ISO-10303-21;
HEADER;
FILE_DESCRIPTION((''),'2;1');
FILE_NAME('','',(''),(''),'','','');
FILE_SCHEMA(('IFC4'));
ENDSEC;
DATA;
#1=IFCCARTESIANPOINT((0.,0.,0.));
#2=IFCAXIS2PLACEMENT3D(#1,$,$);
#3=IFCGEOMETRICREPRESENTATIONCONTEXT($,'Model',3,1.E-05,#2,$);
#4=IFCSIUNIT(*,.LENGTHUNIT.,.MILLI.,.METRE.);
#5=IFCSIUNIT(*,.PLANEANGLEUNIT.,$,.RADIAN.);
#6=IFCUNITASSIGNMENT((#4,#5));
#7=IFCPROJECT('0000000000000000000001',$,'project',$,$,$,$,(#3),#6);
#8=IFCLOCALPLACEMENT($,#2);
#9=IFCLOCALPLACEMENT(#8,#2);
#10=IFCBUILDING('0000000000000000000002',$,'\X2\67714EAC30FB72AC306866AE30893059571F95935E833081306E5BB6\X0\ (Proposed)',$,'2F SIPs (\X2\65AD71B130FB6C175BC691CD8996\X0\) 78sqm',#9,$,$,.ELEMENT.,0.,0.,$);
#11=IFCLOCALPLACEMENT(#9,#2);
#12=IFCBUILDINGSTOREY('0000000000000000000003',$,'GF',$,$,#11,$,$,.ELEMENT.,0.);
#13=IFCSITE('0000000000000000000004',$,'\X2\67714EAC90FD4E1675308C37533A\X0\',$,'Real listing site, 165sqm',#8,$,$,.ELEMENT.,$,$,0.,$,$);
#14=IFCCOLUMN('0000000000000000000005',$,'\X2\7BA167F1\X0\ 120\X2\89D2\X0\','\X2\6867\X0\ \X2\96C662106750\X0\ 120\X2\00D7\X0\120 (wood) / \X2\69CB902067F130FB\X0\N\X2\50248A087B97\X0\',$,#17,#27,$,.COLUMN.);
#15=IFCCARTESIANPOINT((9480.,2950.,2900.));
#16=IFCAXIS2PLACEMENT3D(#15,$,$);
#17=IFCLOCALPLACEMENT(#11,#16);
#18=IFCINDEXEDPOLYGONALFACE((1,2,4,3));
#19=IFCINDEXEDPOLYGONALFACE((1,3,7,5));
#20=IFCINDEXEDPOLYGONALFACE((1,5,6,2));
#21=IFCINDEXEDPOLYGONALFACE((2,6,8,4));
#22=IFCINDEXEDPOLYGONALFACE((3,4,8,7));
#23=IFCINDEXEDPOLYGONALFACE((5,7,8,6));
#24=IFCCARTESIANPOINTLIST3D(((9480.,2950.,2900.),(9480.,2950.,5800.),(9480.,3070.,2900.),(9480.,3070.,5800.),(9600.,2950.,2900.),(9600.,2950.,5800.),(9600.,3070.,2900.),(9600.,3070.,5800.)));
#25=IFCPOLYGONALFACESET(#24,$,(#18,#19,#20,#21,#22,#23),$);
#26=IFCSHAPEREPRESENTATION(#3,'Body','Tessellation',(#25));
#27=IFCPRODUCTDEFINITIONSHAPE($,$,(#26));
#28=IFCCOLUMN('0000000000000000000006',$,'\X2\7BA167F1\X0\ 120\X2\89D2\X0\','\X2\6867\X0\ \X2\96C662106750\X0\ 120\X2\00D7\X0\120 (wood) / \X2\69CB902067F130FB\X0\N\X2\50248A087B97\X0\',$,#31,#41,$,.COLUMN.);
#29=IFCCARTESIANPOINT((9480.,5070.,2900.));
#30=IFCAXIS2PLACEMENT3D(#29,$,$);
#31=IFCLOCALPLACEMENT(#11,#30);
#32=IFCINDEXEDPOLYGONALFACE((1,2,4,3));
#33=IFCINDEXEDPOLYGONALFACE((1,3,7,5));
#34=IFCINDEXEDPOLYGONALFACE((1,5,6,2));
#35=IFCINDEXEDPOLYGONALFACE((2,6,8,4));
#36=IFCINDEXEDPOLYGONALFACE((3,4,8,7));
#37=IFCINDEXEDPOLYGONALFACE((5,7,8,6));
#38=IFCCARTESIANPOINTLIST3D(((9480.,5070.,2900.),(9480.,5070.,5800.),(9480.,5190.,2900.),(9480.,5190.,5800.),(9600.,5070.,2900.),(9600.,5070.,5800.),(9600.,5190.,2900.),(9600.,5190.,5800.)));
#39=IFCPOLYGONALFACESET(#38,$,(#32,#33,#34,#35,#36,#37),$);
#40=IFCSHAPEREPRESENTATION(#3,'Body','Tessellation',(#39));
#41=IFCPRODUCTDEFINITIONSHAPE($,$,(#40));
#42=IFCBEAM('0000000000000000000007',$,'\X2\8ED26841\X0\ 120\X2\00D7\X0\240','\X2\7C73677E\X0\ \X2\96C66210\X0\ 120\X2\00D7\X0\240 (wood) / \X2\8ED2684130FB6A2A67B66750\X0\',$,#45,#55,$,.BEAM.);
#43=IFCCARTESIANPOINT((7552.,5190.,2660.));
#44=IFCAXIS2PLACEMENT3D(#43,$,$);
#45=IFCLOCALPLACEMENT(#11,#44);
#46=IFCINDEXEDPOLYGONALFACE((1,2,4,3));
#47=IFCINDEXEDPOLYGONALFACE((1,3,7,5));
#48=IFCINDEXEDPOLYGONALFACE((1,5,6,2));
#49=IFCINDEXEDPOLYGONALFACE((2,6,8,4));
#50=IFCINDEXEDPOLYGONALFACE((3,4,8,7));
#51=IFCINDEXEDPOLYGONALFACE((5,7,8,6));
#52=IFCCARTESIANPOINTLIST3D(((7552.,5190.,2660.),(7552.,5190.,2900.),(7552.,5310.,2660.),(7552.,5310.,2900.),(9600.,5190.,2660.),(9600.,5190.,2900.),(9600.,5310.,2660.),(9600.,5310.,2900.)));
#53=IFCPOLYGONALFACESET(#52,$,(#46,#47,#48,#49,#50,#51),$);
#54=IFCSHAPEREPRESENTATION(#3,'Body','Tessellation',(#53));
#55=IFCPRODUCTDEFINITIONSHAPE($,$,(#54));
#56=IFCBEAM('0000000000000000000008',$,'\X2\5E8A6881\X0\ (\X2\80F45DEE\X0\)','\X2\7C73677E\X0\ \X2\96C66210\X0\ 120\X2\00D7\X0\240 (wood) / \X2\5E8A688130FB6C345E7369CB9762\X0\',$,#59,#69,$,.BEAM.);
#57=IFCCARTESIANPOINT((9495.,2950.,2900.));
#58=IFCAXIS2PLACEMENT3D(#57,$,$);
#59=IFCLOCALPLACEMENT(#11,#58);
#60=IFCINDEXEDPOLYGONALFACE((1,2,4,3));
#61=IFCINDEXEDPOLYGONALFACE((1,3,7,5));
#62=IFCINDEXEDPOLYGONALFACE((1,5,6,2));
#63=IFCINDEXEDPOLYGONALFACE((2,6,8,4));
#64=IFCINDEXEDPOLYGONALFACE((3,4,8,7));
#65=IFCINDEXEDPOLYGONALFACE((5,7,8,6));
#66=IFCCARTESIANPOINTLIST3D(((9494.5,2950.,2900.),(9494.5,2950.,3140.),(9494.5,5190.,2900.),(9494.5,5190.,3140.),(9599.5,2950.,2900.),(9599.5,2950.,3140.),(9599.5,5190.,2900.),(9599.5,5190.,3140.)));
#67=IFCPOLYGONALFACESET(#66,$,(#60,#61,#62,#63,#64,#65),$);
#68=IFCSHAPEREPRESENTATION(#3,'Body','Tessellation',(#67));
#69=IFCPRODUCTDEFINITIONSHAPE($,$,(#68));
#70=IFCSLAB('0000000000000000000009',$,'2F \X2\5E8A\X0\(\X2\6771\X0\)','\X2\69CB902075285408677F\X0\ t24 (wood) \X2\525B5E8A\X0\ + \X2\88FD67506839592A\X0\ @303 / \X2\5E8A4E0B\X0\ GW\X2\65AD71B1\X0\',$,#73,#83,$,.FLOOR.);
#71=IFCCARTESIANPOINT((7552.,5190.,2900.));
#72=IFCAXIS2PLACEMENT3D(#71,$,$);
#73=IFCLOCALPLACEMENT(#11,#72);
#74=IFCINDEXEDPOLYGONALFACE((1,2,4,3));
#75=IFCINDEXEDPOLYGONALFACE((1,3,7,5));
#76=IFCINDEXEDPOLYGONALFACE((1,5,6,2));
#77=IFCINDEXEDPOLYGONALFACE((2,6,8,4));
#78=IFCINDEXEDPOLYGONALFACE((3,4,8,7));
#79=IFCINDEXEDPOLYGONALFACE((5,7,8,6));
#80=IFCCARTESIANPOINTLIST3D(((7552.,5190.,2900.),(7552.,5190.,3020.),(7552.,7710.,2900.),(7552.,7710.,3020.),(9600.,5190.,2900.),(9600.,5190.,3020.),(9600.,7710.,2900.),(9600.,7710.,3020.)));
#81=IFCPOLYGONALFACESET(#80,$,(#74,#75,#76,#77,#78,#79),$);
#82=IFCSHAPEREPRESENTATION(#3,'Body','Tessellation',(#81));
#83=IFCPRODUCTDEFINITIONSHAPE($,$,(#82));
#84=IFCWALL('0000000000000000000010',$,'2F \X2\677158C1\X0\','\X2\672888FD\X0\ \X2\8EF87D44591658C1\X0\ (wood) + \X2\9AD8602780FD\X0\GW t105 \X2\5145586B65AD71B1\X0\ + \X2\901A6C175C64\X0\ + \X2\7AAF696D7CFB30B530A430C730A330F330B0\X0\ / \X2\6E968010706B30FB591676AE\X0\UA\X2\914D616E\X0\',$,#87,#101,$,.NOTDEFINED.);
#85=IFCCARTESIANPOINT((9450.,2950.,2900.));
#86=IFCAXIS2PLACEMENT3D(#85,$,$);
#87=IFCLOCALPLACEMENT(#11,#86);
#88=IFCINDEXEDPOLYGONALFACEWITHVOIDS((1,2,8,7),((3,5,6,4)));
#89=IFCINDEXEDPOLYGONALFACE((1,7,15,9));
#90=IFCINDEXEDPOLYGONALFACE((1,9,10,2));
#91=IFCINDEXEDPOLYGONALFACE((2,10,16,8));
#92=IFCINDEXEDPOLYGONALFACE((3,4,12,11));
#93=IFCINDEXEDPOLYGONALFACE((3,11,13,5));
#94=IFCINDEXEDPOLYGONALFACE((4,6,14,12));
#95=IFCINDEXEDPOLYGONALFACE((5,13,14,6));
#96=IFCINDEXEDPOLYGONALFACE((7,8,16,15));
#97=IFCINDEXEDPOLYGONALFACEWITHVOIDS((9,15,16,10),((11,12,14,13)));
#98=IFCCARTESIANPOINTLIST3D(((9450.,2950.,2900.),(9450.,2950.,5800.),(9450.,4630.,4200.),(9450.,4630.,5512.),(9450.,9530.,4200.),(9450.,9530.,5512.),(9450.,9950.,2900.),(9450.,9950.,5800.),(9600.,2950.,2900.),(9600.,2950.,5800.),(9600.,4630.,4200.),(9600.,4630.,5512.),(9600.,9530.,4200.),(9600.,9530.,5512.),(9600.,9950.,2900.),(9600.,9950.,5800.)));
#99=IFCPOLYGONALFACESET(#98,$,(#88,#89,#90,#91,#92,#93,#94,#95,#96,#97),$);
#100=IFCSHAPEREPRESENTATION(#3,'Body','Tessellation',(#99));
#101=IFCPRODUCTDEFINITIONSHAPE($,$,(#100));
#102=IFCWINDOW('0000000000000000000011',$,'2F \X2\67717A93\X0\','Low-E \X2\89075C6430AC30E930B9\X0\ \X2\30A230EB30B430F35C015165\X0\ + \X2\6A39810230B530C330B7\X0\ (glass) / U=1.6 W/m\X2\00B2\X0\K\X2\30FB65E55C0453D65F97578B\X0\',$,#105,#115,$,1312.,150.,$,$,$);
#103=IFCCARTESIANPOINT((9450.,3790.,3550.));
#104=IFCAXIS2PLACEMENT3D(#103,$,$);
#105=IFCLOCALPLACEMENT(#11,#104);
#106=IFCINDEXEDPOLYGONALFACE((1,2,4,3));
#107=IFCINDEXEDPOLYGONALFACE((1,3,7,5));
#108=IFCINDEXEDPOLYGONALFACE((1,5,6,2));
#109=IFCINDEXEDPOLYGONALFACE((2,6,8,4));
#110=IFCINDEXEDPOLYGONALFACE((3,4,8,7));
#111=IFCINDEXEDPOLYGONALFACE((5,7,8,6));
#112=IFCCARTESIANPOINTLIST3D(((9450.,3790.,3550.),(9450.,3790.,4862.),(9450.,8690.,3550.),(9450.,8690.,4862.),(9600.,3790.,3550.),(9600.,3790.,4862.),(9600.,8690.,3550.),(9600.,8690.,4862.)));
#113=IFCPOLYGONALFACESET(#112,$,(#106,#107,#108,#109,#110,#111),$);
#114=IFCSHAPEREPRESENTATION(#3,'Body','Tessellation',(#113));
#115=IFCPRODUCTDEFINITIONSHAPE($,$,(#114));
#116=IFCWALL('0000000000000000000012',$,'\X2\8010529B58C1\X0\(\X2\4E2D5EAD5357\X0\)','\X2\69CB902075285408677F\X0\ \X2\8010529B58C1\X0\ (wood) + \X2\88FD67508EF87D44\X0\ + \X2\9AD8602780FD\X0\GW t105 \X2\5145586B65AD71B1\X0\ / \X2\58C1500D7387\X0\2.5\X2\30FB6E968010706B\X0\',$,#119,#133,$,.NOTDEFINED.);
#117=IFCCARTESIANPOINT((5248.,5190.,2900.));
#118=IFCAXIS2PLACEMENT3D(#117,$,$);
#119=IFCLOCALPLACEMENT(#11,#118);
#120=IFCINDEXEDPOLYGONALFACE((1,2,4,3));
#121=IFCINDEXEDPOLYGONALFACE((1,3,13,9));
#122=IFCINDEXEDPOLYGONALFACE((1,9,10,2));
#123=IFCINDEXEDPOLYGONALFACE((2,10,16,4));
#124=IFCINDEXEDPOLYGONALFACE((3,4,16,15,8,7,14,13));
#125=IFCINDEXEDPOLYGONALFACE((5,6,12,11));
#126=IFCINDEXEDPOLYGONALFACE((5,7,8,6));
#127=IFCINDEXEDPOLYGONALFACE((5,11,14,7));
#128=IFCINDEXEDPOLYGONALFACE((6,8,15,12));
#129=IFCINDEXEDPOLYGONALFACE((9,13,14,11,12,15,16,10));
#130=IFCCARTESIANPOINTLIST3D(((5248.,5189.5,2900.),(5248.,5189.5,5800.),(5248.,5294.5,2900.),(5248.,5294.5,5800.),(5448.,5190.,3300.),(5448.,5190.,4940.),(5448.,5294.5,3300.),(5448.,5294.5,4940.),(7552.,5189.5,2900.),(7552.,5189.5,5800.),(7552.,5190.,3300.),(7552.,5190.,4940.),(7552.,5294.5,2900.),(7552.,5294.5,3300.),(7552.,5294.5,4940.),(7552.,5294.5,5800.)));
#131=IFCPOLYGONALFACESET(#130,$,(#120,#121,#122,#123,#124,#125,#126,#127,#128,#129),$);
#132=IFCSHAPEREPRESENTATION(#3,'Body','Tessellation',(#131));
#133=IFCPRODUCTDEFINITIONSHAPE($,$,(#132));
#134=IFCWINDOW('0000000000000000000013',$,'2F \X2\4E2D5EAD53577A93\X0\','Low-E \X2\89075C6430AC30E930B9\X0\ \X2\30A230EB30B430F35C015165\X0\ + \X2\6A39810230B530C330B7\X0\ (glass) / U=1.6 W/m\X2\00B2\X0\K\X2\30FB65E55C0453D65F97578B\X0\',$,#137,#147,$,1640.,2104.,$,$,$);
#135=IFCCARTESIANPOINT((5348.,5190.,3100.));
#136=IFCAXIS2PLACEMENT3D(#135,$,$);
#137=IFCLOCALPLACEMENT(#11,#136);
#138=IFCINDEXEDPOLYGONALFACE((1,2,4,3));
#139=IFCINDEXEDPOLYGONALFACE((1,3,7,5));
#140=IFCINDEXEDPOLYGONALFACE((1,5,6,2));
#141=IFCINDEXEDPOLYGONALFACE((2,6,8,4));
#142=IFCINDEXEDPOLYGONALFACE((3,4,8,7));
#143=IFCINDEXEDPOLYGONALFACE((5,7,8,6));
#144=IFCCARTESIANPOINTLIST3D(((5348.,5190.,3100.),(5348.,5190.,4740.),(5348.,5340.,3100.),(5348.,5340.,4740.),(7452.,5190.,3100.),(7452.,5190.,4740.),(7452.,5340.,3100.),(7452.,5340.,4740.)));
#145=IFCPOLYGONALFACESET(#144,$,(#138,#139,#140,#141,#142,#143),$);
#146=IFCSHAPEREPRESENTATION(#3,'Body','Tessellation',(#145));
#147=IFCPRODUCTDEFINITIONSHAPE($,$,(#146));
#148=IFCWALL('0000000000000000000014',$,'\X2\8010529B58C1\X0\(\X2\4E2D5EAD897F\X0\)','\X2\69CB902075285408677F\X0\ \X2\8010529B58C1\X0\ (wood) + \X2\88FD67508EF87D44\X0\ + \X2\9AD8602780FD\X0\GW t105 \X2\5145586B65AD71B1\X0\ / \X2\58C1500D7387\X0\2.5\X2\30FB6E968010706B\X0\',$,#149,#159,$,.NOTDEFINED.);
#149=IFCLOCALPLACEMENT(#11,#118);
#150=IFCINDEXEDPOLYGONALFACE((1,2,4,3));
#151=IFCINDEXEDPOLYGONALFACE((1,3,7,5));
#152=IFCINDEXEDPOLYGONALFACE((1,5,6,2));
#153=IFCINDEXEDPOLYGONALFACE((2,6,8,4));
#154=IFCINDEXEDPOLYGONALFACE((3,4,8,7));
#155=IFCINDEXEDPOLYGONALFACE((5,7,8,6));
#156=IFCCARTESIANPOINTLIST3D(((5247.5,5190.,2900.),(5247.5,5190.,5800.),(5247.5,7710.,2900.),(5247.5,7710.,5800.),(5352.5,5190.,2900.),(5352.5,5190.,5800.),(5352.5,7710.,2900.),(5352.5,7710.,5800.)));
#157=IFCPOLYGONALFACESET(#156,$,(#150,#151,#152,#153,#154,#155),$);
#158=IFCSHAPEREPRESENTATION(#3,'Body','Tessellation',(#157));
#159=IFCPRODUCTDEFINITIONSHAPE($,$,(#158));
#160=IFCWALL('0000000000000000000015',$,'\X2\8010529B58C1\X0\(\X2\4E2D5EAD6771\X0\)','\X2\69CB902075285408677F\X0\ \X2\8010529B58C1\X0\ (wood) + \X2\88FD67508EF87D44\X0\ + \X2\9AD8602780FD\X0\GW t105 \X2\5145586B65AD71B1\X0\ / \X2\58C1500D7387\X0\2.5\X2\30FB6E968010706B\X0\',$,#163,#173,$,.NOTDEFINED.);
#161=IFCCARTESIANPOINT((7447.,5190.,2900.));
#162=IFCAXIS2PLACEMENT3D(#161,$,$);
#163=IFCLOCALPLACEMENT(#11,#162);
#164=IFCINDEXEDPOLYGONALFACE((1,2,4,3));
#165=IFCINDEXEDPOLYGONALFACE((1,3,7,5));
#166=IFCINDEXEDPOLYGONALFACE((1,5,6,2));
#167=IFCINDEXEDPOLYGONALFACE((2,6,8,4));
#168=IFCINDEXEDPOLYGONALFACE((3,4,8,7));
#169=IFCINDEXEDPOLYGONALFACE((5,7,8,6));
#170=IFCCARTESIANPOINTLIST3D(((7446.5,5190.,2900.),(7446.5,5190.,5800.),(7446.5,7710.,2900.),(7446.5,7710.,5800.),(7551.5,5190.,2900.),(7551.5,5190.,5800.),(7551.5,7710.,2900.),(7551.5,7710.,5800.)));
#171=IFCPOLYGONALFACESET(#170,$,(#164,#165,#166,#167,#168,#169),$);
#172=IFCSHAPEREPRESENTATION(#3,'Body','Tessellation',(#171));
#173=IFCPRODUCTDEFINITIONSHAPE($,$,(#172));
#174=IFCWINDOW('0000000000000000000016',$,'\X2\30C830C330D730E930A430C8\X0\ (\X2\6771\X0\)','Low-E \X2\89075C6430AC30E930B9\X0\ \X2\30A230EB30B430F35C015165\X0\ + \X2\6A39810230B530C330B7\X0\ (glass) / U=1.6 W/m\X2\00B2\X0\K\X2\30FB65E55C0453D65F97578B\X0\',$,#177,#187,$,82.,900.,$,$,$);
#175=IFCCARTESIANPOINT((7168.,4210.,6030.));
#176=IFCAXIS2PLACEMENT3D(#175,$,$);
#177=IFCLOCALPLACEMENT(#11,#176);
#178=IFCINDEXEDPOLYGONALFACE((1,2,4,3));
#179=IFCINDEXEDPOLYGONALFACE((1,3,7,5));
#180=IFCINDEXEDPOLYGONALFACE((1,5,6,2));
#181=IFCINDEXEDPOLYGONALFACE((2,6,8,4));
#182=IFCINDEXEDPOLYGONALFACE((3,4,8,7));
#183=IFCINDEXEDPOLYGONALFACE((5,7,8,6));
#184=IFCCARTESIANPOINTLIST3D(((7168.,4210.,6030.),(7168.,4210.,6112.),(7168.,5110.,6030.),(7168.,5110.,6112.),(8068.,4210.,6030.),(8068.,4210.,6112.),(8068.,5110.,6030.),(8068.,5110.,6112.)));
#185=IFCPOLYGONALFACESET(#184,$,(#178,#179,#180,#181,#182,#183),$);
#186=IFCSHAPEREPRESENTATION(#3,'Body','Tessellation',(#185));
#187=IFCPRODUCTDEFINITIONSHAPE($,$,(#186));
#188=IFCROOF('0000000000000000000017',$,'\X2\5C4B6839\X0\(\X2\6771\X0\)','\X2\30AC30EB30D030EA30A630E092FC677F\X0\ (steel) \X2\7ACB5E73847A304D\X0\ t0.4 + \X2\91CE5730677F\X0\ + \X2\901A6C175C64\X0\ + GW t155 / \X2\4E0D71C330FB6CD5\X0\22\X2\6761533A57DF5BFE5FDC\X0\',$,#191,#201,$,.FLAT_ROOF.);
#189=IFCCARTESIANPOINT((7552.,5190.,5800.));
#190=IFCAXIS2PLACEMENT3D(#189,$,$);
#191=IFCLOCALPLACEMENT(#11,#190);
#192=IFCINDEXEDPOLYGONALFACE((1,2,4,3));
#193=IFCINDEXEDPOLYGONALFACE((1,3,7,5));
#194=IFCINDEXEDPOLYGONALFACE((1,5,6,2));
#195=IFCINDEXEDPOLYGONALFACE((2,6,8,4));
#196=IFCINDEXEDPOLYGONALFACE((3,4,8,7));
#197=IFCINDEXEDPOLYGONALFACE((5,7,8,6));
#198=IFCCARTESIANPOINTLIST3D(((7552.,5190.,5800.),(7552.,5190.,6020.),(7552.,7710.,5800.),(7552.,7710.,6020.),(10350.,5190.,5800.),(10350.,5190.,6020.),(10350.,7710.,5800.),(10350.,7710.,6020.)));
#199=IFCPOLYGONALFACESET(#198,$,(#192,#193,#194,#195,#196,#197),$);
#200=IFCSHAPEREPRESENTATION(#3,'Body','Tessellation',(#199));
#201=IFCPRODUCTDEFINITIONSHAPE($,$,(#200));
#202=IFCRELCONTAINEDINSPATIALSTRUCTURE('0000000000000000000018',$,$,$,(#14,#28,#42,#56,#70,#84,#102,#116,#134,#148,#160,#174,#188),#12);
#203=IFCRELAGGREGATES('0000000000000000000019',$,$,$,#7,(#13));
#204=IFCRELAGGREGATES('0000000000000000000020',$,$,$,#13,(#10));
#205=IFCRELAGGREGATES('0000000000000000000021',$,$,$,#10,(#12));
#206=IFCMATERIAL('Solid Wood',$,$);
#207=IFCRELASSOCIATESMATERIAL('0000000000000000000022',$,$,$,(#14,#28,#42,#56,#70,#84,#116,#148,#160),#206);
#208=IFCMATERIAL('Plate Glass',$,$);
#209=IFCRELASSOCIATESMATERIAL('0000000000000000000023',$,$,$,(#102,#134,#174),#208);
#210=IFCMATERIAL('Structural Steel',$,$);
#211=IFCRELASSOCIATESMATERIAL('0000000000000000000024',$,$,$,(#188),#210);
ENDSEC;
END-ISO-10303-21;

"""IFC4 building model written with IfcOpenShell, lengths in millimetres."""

from ifc_helpers import new_model, si_unit, frame, frame_2d, origin, place, context, project, spatial, rectangle, extrude, material, element, fill, save


model = new_model("IFC4")

# Units and contexts
model_context = context("Model", 3, precision=1e-05, world=origin())
ifc_project = project(units=[si_unit("LENGTHUNIT", "METRE", prefix="MILLI"), si_unit("PLANEANGLEUNIT", "RADIAN")], contexts=[model_context])

# Site, building, storey
site_placement = place(None, origin())
site = spatial("IfcSite", under=ifc_project, at=site_placement, Name="東京都世田谷区", ObjectType="Real listing site, 165sqm", CompositionType="ELEMENT", RefElevation=0.0)
building_placement = place(site_placement, origin())
building = spatial("IfcBuilding", under=site, at=building_placement, Name="東京・犬と暮らす土間広めの家 (Proposed)", ObjectType="2F SIPs (断熱・気密重視) 78sqm", CompositionType="ELEMENT", ElevationOfRefHeight=0.0, ElevationOfTerrain=0.0)
storey_placement = place(building_placement, origin())
storey = spatial("IfcBuildingStorey", under=building, at=storey_placement, Name="GF", CompositionType="ELEMENT", Elevation=0.0)

# Columns
ifc_material_1 = material(Name="Solid Wood")
column_1_placement = place(storey_placement, frame((9480.0, 2950.0, 2900.0)))
element("IfcColumn", 1, at=column_1_placement, inside=storey, material=ifc_material_1, Name="管柱 120角", Description="桧 集成材 120×120 (wood) / 構造柱・N値計算", PredefinedType="COLUMN", context=model_context, shape_type="SweptSolid", body=[
    extrude(rectangle(XDim=120.0, YDim=120.0, at=frame_2d((60.0, 60.0))), frame((9480.0, 2950.0, 2900.0)), (0.0, 0.0, 1.0), 2900.0),
])
column_2_placement = place(storey_placement, frame((9480.0, 5070.0, 2900.0)))
element("IfcColumn", 2, at=column_2_placement, inside=storey, material=ifc_material_1, Name="管柱 120角", Description="桧 集成材 120×120 (wood) / 構造柱・N値計算", PredefinedType="COLUMN", context=model_context, shape_type="SweptSolid", body=[
    extrude(rectangle(XDim=120.0, YDim=120.0, at=frame_2d((60.0, 60.0))), frame((9480.0, 5070.0, 2900.0)), (0.0, 0.0, 1.0), 2900.0),
])

# Beams
beam_1_placement = place(storey_placement, frame((7552.0, 5190.0, 2660.0)))
element("IfcBeam", 3, at=beam_1_placement, inside=storey, material=ifc_material_1, Name="軒桁 120×240", Description="米松 集成 120×240 (wood) / 軒桁・横架材", PredefinedType="BEAM", context=model_context, shape_type="SweptSolid", body=[
    extrude(rectangle(XDim=2048.0, YDim=120.0, at=frame_2d((1024.0, 60.0))), frame((7552.0, 5190.0, 2660.0)), (0.0, 0.0, 1.0), 240.0),
])
beam_2_placement = place(storey_placement, frame((9495.0, 2950.0, 2900.0)))
element("IfcBeam", 4, at=beam_2_placement, inside=storey, material=ifc_material_1, Name="床梁 (胴差)", Description="米松 集成 120×240 (wood) / 床梁・水平構面", PredefinedType="BEAM", context=model_context, shape_type="SweptSolid", body=[
    extrude(rectangle(XDim=105.0, YDim=2240.0, at=frame_2d((52.0, 1120.0))), frame((9495.0, 2950.0, 2900.0)), (0.0, 0.0, 1.0), 240.0),
])

# Slab
slab_placement = place(storey_placement, frame((7552.0, 5190.0, 2900.0)))
element("IfcSlab", 5, at=slab_placement, inside=storey, material=ifc_material_1, Name="2F 床(東)", Description="構造用合板 t24 (wood) 剛床 + 製材根太 @303 / 床下 GW断熱", PredefinedType="FLOOR", context=model_context, shape_type="SweptSolid", body=[
    extrude(rectangle(XDim=2048.0, YDim=2520.0, at=frame_2d((1024.0, 1260.0))), frame((7552.0, 5190.0, 2900.0)), (0.0, 0.0, 1.0), 120.0),
])

# Walls, openings, windows
wall_1_placement = place(storey_placement, frame((9450.0, 2950.0, 2900.0)))
wall_1 = element("IfcWall", 6, at=wall_1_placement, inside=storey, material=ifc_material_1, Name="2F 東壁", Description="木製 軸組外壁 (wood) + 高性能GW t105 充填断熱 + 通気層 + 窯業系サイディング / 準耐火・外皮UA配慮", PredefinedType="NOTDEFINED", context=model_context, shape_type="SweptSolid", body=[
    extrude(rectangle(XDim=150.0, YDim=7000.0, at=frame_2d((75.0, 3500.0))), frame((9450.0, 2950.0, 2900.0)), (0.0, 0.0, 1.0), 2900.0),
])
opening_1_placement = place(storey_placement, frame((9450.0, 3790.0, 3550.0)))
opening_1 = element("IfcOpeningElement", 7, at=opening_1_placement, cuts=wall_1, PredefinedType="NOTDEFINED", context=model_context, shape_type="SweptSolid", body=[
    extrude(rectangle(XDim=150.0, YDim=4900.0, at=frame_2d((75.0, 2450.0))), frame((9450.0, 3790.0, 3550.0)), (0.0, 0.0, 1.0), 1312.0),
])
ifc_material_2 = material(Name="Plate Glass")
window_1_placement = place(storey_placement, frame((9450.0, 3790.0, 3550.0)))
window_1 = element("IfcWindow", 8, at=window_1_placement, inside=storey, material=ifc_material_2, Name="2F 東窓", Description="Low-E 複層ガラス アルゴン封入 + 樹脂サッシ (glass) / U=1.6 W/m²K・日射取得型", OverallHeight=1312.0, OverallWidth=150.0, context=model_context, shape_type="SweptSolid", body=[
    extrude(rectangle(XDim=150.0, YDim=4900.0, at=frame_2d((75.0, 2450.0))), frame((9450.0, 3790.0, 3550.0)), (0.0, 0.0, 1.0), 1312.0),
])
fill(opening_1, window_1)
wall_2_placement = place(storey_placement, frame((5248.0, 5190.0, 2900.0)))
wall_2 = element("IfcWall", 9, at=wall_2_placement, inside=storey, material=ifc_material_1, Name="耐力壁(中庭南)", Description="構造用合板 耐力壁 (wood) + 製材軸組 + 高性能GW t105 充填断熱 / 壁倍率2.5・準耐火", PredefinedType="NOTDEFINED", context=model_context, shape_type="SweptSolid", body=[
    extrude(rectangle(XDim=2304.0, YDim=105.0, at=frame_2d((1152.0, 52.0))), frame((5248.0, 5190.0, 2900.0)), (0.0, 0.0, 1.0), 2900.0),
])
opening_2_placement = place(storey_placement, frame((5348.0, 5190.0, 3100.0)))
opening_2 = element("IfcOpeningElement", 10, at=opening_2_placement, cuts=wall_2, PredefinedType="NOTDEFINED", context=model_context, shape_type="SweptSolid", body=[
    extrude(rectangle(XDim=2104.0, YDim=150.0, at=frame_2d((1052.0, 75.0))), frame((5348.0, 5190.0, 3100.0)), (0.0, 0.0, 1.0), 1640.0),
])
window_2_placement = place(storey_placement, frame((5348.0, 5190.0, 3100.0)))
window_2 = element("IfcWindow", 11, at=window_2_placement, inside=storey, material=ifc_material_2, Name="2F 中庭南窓", Description="Low-E 複層ガラス アルゴン封入 + 樹脂サッシ (glass) / U=1.6 W/m²K・日射取得型", OverallHeight=1640.0, OverallWidth=2104.0, context=model_context, shape_type="SweptSolid", body=[
    extrude(rectangle(XDim=2104.0, YDim=150.0, at=frame_2d((1052.0, 75.0))), frame((5348.0, 5190.0, 3100.0)), (0.0, 0.0, 1.0), 1640.0),
])
fill(opening_2, window_2)

# Walls
wall_3_placement = place(storey_placement, frame((5248.0, 5190.0, 2900.0)))
element("IfcWall", 12, at=wall_3_placement, inside=storey, material=ifc_material_1, Name="耐力壁(中庭西)", Description="構造用合板 耐力壁 (wood) + 製材軸組 + 高性能GW t105 充填断熱 / 壁倍率2.5・準耐火", PredefinedType="NOTDEFINED", context=model_context, shape_type="SweptSolid", body=[
    extrude(rectangle(XDim=105.0, YDim=2520.0, at=frame_2d((52.0, 1260.0))), frame((5248.0, 5190.0, 2900.0)), (0.0, 0.0, 1.0), 2900.0),
])
wall_4_placement = place(storey_placement, frame((7447.0, 5190.0, 2900.0)))
element("IfcWall", 13, at=wall_4_placement, inside=storey, material=ifc_material_1, Name="耐力壁(中庭東)", Description="構造用合板 耐力壁 (wood) + 製材軸組 + 高性能GW t105 充填断熱 / 壁倍率2.5・準耐火", PredefinedType="NOTDEFINED", context=model_context, shape_type="SweptSolid", body=[
    extrude(rectangle(XDim=105.0, YDim=2520.0, at=frame_2d((52.0, 1260.0))), frame((7447.0, 5190.0, 2900.0)), (0.0, 0.0, 1.0), 2900.0),
])

# Window
window_3_placement = place(storey_placement, frame((7168.0, 4210.0, 6030.0)))
element("IfcWindow", 14, at=window_3_placement, inside=storey, material=ifc_material_2, Name="トップライト (東)", Description="Low-E 複層ガラス アルゴン封入 + 樹脂サッシ (glass) / U=1.6 W/m²K・日射取得型", OverallHeight=82.0, OverallWidth=900.0, context=model_context, shape_type="SweptSolid", body=[
    extrude(rectangle(XDim=900.0, YDim=900.0, at=frame_2d((450.0, 450.0))), frame((7168.0, 4210.0, 6030.0)), (0.0, 0.0, 1.0), 82.0),
])

# Roof
ifc_material_3 = material(Name="Structural Steel")
for number, where, name in (
    (15, (7552.0, 5190.0, 5800.0), "屋根(東)"),
):
    element("IfcRoof", number, at=place(storey_placement, frame(where)), inside=storey, material=ifc_material_3, Name=name, Description="ガルバリウム鋼板 (steel) 立平葺き t0.4 + 野地板 + 通気層 + GW t155 / 不燃・法22条区域対応", PredefinedType="FLAT_ROOF", context=model_context, shape_type="SweptSolid", body=[
        extrude(rectangle(XDim=2798.0, YDim=2520.0, at=frame_2d((1399.0, 1260.0))), frame((7552.0, 5190.0, 5800.0)), (0.0, 0.0, 1.0), 220.0),
    ])

save(model, "model.ifc")
